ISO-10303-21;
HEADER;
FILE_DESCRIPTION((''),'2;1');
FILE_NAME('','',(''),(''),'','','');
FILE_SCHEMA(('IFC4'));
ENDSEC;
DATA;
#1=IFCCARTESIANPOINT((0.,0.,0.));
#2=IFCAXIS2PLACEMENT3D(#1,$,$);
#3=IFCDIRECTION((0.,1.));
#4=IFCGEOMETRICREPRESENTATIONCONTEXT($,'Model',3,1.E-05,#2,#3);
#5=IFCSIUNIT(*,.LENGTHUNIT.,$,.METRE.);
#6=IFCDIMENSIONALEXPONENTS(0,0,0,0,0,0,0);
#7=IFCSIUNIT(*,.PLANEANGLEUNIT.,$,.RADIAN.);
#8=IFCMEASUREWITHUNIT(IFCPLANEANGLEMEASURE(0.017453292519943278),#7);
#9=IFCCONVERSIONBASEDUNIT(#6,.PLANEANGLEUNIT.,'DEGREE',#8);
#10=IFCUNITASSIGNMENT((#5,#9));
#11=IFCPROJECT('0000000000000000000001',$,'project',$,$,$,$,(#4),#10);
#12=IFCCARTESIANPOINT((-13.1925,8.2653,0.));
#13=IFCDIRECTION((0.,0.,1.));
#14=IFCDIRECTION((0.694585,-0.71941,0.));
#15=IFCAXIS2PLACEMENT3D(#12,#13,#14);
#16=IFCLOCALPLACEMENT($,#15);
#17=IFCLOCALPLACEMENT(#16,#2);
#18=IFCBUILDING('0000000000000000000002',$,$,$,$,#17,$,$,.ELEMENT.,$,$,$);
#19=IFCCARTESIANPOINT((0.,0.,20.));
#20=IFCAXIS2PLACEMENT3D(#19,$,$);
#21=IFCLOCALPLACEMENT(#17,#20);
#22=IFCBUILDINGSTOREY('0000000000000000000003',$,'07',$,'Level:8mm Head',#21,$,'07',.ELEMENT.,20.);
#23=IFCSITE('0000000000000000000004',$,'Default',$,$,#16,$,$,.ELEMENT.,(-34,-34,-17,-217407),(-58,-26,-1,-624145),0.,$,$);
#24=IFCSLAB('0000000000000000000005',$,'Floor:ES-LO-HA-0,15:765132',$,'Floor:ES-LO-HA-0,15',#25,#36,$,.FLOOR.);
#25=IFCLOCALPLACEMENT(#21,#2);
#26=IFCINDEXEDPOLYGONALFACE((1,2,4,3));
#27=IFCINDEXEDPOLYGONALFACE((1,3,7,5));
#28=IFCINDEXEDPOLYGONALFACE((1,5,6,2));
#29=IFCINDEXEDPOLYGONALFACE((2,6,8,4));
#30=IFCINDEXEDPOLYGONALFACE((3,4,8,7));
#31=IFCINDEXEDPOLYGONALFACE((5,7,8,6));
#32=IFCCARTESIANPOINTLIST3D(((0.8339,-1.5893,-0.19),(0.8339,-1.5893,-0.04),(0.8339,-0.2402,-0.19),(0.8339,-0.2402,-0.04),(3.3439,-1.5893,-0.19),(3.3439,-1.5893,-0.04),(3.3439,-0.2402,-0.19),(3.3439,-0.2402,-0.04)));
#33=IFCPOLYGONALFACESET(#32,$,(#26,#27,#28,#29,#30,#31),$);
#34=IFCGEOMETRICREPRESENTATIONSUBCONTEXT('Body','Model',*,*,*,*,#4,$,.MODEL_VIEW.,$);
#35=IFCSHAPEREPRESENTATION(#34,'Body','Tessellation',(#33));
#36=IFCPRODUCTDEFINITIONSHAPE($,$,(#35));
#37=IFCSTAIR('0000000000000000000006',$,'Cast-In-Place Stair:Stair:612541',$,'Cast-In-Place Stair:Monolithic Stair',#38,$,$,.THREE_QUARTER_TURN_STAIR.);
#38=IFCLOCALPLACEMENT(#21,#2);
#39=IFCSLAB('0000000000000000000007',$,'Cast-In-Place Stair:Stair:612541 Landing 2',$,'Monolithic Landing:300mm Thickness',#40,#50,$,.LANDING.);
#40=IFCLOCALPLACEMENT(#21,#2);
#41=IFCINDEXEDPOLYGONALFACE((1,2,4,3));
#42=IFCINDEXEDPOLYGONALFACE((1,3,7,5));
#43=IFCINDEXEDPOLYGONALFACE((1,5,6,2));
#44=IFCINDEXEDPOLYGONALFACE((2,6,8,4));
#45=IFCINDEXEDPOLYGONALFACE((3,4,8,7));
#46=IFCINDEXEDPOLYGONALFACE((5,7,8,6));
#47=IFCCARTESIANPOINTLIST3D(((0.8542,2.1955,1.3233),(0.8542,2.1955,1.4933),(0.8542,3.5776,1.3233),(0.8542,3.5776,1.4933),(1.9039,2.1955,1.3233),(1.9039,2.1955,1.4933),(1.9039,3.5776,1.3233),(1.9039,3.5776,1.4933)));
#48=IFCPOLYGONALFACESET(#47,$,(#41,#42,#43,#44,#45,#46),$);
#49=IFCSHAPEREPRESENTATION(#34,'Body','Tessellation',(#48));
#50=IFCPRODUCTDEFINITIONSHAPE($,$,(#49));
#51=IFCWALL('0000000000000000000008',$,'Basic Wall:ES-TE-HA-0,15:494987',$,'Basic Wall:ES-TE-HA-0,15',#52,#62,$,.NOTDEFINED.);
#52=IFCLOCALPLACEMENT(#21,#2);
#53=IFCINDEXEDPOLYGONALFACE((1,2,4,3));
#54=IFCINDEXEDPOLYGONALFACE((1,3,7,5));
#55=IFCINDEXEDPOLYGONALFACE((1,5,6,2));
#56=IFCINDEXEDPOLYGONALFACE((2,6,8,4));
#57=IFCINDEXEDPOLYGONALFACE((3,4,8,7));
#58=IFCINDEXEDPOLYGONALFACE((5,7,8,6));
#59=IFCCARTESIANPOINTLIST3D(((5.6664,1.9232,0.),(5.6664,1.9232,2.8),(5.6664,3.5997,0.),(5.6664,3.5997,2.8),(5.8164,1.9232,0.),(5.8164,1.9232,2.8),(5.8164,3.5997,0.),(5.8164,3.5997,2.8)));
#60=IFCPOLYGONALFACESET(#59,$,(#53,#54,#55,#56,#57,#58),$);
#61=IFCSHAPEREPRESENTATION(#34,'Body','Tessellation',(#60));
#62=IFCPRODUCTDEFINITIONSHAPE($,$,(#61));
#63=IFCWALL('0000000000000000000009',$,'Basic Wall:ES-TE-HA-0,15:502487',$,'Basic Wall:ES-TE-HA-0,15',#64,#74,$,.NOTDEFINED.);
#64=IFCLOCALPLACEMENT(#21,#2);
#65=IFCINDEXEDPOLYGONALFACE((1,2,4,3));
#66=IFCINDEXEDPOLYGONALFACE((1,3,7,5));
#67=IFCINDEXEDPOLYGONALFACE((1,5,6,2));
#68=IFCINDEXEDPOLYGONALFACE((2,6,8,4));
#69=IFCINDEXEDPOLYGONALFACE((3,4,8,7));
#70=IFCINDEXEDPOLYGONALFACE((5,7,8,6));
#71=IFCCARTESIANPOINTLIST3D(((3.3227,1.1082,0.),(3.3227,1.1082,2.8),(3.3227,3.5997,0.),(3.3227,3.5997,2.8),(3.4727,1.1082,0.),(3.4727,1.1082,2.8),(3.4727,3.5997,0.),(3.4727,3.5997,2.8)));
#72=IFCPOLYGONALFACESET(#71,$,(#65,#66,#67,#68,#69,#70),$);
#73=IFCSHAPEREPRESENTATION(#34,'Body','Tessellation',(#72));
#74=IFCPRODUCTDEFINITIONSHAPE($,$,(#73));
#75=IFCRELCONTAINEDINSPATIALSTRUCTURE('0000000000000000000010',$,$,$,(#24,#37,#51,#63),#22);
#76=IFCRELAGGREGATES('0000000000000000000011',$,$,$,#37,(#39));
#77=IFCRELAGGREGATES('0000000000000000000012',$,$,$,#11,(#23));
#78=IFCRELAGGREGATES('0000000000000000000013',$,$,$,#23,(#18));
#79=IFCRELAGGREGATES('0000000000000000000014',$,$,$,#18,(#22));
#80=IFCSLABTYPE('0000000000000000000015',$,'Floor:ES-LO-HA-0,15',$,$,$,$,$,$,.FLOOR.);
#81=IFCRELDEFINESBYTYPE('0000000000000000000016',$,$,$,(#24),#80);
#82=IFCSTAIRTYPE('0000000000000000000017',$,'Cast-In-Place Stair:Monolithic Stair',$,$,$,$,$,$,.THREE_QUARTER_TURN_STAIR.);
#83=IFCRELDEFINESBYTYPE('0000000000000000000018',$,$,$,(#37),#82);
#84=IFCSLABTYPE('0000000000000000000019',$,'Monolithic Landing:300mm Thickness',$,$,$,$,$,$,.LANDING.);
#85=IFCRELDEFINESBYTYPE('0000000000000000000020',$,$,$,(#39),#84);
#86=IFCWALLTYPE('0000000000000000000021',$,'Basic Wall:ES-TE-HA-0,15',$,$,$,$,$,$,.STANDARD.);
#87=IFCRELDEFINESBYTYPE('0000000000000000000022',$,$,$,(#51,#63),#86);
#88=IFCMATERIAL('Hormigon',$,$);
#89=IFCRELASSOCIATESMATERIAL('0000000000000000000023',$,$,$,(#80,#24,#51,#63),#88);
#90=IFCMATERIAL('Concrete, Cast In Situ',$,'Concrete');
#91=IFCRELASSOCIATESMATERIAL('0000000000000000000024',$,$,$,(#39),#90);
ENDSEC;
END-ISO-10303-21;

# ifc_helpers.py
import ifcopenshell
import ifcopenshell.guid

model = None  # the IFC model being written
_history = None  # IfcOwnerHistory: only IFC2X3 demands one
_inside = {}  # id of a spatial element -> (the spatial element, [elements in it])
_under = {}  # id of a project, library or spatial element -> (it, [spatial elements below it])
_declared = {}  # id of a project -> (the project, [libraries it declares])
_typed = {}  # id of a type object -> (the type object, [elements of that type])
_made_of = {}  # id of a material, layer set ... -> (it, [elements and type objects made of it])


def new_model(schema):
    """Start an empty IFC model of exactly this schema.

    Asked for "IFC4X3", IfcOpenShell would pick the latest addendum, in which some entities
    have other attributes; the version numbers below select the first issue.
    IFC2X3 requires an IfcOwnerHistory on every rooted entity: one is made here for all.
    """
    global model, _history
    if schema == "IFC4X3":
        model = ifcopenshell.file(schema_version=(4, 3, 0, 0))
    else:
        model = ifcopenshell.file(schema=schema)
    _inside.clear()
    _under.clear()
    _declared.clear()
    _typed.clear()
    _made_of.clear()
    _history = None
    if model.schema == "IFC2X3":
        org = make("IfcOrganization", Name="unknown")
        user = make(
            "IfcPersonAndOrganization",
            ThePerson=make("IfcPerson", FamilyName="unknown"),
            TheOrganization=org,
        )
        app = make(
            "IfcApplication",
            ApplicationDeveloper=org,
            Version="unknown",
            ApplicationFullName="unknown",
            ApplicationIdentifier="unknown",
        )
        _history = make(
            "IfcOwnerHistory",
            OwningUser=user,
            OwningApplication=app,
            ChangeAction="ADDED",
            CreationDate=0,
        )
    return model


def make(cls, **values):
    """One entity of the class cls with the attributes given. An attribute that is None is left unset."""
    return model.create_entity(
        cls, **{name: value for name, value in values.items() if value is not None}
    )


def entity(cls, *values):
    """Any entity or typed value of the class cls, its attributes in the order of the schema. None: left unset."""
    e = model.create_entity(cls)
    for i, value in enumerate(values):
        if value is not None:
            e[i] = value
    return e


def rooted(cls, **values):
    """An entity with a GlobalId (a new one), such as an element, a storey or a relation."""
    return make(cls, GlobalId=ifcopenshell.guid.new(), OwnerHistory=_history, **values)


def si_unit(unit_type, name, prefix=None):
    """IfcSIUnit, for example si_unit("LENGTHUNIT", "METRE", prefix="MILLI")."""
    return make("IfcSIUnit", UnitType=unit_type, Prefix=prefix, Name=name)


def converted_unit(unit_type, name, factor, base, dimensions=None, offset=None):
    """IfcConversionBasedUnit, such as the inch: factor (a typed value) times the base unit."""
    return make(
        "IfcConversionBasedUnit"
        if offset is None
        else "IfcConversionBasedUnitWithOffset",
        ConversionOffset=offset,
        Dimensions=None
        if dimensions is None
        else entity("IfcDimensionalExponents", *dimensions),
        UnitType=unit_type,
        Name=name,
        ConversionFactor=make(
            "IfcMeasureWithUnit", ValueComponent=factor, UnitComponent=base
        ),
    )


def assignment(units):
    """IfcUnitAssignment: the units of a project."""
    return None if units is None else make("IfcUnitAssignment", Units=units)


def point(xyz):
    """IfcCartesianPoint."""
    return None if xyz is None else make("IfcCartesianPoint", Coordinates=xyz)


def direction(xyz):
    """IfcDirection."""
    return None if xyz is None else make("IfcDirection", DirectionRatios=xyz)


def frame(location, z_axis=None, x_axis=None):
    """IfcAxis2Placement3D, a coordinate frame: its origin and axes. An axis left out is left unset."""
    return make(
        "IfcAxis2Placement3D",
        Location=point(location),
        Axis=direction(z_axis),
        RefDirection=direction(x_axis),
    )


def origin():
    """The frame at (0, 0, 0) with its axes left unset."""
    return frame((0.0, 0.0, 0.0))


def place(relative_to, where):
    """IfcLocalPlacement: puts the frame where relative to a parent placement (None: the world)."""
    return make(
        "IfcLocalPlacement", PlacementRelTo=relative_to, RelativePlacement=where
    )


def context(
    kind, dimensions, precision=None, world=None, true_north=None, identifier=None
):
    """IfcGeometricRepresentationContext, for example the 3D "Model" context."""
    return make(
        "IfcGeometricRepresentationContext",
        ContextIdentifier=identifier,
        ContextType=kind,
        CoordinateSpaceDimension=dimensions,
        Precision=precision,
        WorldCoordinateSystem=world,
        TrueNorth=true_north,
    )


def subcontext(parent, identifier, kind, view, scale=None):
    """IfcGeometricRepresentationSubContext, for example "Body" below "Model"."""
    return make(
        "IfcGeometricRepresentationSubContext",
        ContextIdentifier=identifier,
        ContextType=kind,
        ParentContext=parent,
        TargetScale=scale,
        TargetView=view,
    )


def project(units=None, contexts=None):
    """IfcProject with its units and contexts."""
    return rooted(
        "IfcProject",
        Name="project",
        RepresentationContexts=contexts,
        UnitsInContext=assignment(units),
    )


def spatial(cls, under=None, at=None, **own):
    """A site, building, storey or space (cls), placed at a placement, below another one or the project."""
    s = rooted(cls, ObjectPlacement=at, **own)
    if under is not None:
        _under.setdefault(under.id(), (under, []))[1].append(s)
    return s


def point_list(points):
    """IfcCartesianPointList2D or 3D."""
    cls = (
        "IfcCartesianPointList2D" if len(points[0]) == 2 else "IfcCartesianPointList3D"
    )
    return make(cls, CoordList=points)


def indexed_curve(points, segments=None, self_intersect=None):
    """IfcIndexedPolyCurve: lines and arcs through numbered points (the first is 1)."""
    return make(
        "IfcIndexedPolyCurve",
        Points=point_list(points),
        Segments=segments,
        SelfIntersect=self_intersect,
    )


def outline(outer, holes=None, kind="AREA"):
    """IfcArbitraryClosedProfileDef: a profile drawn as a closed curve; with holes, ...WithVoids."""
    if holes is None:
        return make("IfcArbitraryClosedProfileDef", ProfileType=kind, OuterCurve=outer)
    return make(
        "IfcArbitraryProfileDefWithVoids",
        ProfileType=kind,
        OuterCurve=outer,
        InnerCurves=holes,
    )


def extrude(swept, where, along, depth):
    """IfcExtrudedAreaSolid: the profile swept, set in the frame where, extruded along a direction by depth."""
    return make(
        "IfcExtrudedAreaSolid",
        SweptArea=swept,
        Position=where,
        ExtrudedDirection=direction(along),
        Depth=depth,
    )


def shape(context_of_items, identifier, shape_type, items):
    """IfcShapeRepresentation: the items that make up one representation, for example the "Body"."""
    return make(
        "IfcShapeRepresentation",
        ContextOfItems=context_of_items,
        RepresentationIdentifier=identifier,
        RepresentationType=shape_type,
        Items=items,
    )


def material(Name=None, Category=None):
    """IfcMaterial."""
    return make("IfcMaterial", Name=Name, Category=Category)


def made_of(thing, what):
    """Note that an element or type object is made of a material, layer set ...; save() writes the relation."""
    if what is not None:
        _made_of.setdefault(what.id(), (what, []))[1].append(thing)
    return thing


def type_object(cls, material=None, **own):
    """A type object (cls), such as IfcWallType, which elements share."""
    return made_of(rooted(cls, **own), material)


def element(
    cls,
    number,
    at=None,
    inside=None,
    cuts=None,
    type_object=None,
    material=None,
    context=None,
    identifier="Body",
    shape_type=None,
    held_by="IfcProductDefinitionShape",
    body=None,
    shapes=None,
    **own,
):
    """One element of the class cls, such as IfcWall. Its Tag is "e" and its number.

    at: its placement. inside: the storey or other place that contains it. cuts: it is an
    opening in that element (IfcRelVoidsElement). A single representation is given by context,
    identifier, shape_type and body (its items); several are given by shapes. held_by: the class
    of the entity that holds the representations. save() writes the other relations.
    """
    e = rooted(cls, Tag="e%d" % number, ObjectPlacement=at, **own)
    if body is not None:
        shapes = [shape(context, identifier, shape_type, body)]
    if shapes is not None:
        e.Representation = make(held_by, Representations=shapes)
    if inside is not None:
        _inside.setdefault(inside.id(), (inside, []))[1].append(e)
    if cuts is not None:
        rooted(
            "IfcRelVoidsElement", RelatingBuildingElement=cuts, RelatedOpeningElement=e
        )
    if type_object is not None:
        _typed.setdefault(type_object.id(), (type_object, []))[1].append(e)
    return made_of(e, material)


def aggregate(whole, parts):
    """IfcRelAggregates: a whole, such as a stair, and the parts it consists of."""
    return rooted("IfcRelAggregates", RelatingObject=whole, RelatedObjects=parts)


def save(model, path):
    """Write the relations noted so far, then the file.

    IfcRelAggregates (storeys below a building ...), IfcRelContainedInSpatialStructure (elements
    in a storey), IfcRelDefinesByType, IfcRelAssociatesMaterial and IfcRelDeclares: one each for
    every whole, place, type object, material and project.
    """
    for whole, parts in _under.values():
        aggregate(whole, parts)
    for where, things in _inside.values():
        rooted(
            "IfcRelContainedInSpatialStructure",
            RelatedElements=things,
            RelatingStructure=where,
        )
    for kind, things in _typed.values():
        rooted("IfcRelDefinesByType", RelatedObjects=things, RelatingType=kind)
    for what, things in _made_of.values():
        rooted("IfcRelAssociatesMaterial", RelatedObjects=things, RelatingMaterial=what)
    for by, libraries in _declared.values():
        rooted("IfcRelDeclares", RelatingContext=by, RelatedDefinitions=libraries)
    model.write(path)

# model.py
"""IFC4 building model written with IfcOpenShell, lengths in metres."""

from ifc_helpers import new_model, entity, si_unit, converted_unit, direction, frame, origin, place, context, subcontext, project, spatial, indexed_curve, outline, extrude, material, type_object, element, aggregate, save


model = new_model("IFC4")

# Units and contexts
model_context = context("Model", 3, precision=1e-05, world=origin(), true_north=direction((0.0, 1.0)))
body_context = subcontext(model_context, "Body", "Model", "MODEL_VIEW")
ifc_project = project(units=[si_unit("LENGTHUNIT", "METRE"), converted_unit("PLANEANGLEUNIT", "DEGREE", entity("IfcPlaneAngleMeasure", 0.017453292519943278), si_unit("PLANEANGLEUNIT", "RADIAN"), dimensions=[0, 0, 0, 0, 0, 0, 0])], contexts=[model_context])

# Site, building, storey
site_placement = place(None, frame((-13.1925, 8.2653, 0.0), z_axis=(0.0, 0.0, 1.0), x_axis=(0.694585, -0.71941, 0.0)))
site = spatial("IfcSite", under=ifc_project, at=site_placement, Name="Default", CompositionType="ELEMENT", RefLatitude=(-34, -34, -17, -217407), RefLongitude=(-58, -26, -1, -624145), RefElevation=0.0)
building_placement = place(site_placement, origin())
building = spatial("IfcBuilding", under=site, at=building_placement, CompositionType="ELEMENT")
storey_placement = place(building_placement, frame((0.0, 0.0, 20.0)))
storey = spatial("IfcBuildingStorey", under=building, at=storey_placement, Name="07", ObjectType="Level:8mm Head", LongName="07", CompositionType="ELEMENT", Elevation=20.0)

# Shared definitions
ifc_material_1 = material(Name="Hormigon")
slab_type_1 = type_object("IfcSlabType", Name="Floor:ES-LO-HA-0,15", PredefinedType="FLOOR", material=ifc_material_1)

# Slab
slab_1_placement = place(storey_placement, origin())
element("IfcSlab", 1, at=slab_1_placement, inside=storey, type_object=slab_type_1, material=ifc_material_1, Name="Floor:ES-LO-HA-0,15:765132", ObjectType="Floor:ES-LO-HA-0,15", PredefinedType="FLOOR", context=body_context, shape_type="SweptSolid", body=[
    extrude(outline(indexed_curve([(-0.6746, -1.255), (0.6746, -1.255), (0.6746, 1.255), (-0.6746, 1.255), (-0.6746, -1.255)], self_intersect=False)), frame((2.0889, -0.9147, -0.04), z_axis=(0.0, 0.0, -1.0), x_axis=(0.0, 1.0, 0.0)), (0.0, 0.0, 1.0), 0.15),
])

# Stair, slab
stair_type = type_object("IfcStairType", Name="Cast-In-Place Stair:Monolithic Stair", PredefinedType="THREE_QUARTER_TURN_STAIR")
stair_placement = place(storey_placement, origin())
stair = element("IfcStair", 2, at=stair_placement, inside=storey, type_object=stair_type, Name="Cast-In-Place Stair:Stair:612541", ObjectType="Cast-In-Place Stair:Monolithic Stair", PredefinedType="THREE_QUARTER_TURN_STAIR")
ifc_material_2 = material(Name="Concrete, Cast In Situ", Category="Concrete")
slab_type_2 = type_object("IfcSlabType", Name="Monolithic Landing:300mm Thickness", PredefinedType="LANDING")
slab_2_placement = place(stair_placement, origin())
slab_2 = element("IfcSlab", 3, at=slab_2_placement, type_object=slab_type_2, material=ifc_material_2, Name="Cast-In-Place Stair:Stair:612541 Landing 2", ObjectType="Monolithic Landing:300mm Thickness", PredefinedType="LANDING", context=body_context, shape_type="SweptSolid", body=[
    extrude(outline(indexed_curve([(-0.6911, -0.5249), (0.6911, -0.5249), (0.6911, 0.5249), (-0.6911, 0.5249), (-0.6911, -0.5249)], self_intersect=False)), frame((1.379, 2.8866, 1.3233), z_axis=(0.0, 0.0, 1.0), x_axis=(0.0, 1.0, 0.0)), (0.0, 0.0, 1.0), 0.17),
])

# Walls
wall_type = type_object("IfcWallType", Name="Basic Wall:ES-TE-HA-0,15", PredefinedType="STANDARD")
wall_1_placement = place(storey_placement, frame((5.7414, 1.9232, 0.0), z_axis=(0.0, 0.0, 1.0), x_axis=(0.0, 1.0, 0.0)))
element("IfcWall", 4, at=wall_1_placement, inside=storey, type_object=wall_type, material=ifc_material_1, Name="Basic Wall:ES-TE-HA-0,15:494987", ObjectType="Basic Wall:ES-TE-HA-0,15", PredefinedType="NOTDEFINED", context=body_context, shape_type="SweptSolid", body=[
    extrude(outline(indexed_curve([(1.6765, 0.075), (0.0, 0.075), (0.0, -0.075), (1.6765, -0.075), (1.6765, 0.075)], self_intersect=False)), origin(), (0.0, 0.0, 1.0), 2.8),
])
wall_2_placement = place(storey_placement, frame((3.3977, 3.5997, 0.0), z_axis=(0.0, 0.0, 1.0), x_axis=(0.0, -1.0, 0.0)))
element("IfcWall", 5, at=wall_2_placement, inside=storey, type_object=wall_type, material=ifc_material_1, Name="Basic Wall:ES-TE-HA-0,15:502487", ObjectType="Basic Wall:ES-TE-HA-0,15", PredefinedType="NOTDEFINED", context=body_context, shape_type="SweptSolid", body=[
    extrude(outline(indexed_curve([(2.4915, 0.075), (0.0, 0.075), (0.0, -0.075), (2.4915, -0.075), (2.4915, 0.075)], self_intersect=False)), origin(), (0.0, 0.0, 1.0), 2.8),
])

aggregate(stair, [slab_2])

save(model, "model.ifc")
